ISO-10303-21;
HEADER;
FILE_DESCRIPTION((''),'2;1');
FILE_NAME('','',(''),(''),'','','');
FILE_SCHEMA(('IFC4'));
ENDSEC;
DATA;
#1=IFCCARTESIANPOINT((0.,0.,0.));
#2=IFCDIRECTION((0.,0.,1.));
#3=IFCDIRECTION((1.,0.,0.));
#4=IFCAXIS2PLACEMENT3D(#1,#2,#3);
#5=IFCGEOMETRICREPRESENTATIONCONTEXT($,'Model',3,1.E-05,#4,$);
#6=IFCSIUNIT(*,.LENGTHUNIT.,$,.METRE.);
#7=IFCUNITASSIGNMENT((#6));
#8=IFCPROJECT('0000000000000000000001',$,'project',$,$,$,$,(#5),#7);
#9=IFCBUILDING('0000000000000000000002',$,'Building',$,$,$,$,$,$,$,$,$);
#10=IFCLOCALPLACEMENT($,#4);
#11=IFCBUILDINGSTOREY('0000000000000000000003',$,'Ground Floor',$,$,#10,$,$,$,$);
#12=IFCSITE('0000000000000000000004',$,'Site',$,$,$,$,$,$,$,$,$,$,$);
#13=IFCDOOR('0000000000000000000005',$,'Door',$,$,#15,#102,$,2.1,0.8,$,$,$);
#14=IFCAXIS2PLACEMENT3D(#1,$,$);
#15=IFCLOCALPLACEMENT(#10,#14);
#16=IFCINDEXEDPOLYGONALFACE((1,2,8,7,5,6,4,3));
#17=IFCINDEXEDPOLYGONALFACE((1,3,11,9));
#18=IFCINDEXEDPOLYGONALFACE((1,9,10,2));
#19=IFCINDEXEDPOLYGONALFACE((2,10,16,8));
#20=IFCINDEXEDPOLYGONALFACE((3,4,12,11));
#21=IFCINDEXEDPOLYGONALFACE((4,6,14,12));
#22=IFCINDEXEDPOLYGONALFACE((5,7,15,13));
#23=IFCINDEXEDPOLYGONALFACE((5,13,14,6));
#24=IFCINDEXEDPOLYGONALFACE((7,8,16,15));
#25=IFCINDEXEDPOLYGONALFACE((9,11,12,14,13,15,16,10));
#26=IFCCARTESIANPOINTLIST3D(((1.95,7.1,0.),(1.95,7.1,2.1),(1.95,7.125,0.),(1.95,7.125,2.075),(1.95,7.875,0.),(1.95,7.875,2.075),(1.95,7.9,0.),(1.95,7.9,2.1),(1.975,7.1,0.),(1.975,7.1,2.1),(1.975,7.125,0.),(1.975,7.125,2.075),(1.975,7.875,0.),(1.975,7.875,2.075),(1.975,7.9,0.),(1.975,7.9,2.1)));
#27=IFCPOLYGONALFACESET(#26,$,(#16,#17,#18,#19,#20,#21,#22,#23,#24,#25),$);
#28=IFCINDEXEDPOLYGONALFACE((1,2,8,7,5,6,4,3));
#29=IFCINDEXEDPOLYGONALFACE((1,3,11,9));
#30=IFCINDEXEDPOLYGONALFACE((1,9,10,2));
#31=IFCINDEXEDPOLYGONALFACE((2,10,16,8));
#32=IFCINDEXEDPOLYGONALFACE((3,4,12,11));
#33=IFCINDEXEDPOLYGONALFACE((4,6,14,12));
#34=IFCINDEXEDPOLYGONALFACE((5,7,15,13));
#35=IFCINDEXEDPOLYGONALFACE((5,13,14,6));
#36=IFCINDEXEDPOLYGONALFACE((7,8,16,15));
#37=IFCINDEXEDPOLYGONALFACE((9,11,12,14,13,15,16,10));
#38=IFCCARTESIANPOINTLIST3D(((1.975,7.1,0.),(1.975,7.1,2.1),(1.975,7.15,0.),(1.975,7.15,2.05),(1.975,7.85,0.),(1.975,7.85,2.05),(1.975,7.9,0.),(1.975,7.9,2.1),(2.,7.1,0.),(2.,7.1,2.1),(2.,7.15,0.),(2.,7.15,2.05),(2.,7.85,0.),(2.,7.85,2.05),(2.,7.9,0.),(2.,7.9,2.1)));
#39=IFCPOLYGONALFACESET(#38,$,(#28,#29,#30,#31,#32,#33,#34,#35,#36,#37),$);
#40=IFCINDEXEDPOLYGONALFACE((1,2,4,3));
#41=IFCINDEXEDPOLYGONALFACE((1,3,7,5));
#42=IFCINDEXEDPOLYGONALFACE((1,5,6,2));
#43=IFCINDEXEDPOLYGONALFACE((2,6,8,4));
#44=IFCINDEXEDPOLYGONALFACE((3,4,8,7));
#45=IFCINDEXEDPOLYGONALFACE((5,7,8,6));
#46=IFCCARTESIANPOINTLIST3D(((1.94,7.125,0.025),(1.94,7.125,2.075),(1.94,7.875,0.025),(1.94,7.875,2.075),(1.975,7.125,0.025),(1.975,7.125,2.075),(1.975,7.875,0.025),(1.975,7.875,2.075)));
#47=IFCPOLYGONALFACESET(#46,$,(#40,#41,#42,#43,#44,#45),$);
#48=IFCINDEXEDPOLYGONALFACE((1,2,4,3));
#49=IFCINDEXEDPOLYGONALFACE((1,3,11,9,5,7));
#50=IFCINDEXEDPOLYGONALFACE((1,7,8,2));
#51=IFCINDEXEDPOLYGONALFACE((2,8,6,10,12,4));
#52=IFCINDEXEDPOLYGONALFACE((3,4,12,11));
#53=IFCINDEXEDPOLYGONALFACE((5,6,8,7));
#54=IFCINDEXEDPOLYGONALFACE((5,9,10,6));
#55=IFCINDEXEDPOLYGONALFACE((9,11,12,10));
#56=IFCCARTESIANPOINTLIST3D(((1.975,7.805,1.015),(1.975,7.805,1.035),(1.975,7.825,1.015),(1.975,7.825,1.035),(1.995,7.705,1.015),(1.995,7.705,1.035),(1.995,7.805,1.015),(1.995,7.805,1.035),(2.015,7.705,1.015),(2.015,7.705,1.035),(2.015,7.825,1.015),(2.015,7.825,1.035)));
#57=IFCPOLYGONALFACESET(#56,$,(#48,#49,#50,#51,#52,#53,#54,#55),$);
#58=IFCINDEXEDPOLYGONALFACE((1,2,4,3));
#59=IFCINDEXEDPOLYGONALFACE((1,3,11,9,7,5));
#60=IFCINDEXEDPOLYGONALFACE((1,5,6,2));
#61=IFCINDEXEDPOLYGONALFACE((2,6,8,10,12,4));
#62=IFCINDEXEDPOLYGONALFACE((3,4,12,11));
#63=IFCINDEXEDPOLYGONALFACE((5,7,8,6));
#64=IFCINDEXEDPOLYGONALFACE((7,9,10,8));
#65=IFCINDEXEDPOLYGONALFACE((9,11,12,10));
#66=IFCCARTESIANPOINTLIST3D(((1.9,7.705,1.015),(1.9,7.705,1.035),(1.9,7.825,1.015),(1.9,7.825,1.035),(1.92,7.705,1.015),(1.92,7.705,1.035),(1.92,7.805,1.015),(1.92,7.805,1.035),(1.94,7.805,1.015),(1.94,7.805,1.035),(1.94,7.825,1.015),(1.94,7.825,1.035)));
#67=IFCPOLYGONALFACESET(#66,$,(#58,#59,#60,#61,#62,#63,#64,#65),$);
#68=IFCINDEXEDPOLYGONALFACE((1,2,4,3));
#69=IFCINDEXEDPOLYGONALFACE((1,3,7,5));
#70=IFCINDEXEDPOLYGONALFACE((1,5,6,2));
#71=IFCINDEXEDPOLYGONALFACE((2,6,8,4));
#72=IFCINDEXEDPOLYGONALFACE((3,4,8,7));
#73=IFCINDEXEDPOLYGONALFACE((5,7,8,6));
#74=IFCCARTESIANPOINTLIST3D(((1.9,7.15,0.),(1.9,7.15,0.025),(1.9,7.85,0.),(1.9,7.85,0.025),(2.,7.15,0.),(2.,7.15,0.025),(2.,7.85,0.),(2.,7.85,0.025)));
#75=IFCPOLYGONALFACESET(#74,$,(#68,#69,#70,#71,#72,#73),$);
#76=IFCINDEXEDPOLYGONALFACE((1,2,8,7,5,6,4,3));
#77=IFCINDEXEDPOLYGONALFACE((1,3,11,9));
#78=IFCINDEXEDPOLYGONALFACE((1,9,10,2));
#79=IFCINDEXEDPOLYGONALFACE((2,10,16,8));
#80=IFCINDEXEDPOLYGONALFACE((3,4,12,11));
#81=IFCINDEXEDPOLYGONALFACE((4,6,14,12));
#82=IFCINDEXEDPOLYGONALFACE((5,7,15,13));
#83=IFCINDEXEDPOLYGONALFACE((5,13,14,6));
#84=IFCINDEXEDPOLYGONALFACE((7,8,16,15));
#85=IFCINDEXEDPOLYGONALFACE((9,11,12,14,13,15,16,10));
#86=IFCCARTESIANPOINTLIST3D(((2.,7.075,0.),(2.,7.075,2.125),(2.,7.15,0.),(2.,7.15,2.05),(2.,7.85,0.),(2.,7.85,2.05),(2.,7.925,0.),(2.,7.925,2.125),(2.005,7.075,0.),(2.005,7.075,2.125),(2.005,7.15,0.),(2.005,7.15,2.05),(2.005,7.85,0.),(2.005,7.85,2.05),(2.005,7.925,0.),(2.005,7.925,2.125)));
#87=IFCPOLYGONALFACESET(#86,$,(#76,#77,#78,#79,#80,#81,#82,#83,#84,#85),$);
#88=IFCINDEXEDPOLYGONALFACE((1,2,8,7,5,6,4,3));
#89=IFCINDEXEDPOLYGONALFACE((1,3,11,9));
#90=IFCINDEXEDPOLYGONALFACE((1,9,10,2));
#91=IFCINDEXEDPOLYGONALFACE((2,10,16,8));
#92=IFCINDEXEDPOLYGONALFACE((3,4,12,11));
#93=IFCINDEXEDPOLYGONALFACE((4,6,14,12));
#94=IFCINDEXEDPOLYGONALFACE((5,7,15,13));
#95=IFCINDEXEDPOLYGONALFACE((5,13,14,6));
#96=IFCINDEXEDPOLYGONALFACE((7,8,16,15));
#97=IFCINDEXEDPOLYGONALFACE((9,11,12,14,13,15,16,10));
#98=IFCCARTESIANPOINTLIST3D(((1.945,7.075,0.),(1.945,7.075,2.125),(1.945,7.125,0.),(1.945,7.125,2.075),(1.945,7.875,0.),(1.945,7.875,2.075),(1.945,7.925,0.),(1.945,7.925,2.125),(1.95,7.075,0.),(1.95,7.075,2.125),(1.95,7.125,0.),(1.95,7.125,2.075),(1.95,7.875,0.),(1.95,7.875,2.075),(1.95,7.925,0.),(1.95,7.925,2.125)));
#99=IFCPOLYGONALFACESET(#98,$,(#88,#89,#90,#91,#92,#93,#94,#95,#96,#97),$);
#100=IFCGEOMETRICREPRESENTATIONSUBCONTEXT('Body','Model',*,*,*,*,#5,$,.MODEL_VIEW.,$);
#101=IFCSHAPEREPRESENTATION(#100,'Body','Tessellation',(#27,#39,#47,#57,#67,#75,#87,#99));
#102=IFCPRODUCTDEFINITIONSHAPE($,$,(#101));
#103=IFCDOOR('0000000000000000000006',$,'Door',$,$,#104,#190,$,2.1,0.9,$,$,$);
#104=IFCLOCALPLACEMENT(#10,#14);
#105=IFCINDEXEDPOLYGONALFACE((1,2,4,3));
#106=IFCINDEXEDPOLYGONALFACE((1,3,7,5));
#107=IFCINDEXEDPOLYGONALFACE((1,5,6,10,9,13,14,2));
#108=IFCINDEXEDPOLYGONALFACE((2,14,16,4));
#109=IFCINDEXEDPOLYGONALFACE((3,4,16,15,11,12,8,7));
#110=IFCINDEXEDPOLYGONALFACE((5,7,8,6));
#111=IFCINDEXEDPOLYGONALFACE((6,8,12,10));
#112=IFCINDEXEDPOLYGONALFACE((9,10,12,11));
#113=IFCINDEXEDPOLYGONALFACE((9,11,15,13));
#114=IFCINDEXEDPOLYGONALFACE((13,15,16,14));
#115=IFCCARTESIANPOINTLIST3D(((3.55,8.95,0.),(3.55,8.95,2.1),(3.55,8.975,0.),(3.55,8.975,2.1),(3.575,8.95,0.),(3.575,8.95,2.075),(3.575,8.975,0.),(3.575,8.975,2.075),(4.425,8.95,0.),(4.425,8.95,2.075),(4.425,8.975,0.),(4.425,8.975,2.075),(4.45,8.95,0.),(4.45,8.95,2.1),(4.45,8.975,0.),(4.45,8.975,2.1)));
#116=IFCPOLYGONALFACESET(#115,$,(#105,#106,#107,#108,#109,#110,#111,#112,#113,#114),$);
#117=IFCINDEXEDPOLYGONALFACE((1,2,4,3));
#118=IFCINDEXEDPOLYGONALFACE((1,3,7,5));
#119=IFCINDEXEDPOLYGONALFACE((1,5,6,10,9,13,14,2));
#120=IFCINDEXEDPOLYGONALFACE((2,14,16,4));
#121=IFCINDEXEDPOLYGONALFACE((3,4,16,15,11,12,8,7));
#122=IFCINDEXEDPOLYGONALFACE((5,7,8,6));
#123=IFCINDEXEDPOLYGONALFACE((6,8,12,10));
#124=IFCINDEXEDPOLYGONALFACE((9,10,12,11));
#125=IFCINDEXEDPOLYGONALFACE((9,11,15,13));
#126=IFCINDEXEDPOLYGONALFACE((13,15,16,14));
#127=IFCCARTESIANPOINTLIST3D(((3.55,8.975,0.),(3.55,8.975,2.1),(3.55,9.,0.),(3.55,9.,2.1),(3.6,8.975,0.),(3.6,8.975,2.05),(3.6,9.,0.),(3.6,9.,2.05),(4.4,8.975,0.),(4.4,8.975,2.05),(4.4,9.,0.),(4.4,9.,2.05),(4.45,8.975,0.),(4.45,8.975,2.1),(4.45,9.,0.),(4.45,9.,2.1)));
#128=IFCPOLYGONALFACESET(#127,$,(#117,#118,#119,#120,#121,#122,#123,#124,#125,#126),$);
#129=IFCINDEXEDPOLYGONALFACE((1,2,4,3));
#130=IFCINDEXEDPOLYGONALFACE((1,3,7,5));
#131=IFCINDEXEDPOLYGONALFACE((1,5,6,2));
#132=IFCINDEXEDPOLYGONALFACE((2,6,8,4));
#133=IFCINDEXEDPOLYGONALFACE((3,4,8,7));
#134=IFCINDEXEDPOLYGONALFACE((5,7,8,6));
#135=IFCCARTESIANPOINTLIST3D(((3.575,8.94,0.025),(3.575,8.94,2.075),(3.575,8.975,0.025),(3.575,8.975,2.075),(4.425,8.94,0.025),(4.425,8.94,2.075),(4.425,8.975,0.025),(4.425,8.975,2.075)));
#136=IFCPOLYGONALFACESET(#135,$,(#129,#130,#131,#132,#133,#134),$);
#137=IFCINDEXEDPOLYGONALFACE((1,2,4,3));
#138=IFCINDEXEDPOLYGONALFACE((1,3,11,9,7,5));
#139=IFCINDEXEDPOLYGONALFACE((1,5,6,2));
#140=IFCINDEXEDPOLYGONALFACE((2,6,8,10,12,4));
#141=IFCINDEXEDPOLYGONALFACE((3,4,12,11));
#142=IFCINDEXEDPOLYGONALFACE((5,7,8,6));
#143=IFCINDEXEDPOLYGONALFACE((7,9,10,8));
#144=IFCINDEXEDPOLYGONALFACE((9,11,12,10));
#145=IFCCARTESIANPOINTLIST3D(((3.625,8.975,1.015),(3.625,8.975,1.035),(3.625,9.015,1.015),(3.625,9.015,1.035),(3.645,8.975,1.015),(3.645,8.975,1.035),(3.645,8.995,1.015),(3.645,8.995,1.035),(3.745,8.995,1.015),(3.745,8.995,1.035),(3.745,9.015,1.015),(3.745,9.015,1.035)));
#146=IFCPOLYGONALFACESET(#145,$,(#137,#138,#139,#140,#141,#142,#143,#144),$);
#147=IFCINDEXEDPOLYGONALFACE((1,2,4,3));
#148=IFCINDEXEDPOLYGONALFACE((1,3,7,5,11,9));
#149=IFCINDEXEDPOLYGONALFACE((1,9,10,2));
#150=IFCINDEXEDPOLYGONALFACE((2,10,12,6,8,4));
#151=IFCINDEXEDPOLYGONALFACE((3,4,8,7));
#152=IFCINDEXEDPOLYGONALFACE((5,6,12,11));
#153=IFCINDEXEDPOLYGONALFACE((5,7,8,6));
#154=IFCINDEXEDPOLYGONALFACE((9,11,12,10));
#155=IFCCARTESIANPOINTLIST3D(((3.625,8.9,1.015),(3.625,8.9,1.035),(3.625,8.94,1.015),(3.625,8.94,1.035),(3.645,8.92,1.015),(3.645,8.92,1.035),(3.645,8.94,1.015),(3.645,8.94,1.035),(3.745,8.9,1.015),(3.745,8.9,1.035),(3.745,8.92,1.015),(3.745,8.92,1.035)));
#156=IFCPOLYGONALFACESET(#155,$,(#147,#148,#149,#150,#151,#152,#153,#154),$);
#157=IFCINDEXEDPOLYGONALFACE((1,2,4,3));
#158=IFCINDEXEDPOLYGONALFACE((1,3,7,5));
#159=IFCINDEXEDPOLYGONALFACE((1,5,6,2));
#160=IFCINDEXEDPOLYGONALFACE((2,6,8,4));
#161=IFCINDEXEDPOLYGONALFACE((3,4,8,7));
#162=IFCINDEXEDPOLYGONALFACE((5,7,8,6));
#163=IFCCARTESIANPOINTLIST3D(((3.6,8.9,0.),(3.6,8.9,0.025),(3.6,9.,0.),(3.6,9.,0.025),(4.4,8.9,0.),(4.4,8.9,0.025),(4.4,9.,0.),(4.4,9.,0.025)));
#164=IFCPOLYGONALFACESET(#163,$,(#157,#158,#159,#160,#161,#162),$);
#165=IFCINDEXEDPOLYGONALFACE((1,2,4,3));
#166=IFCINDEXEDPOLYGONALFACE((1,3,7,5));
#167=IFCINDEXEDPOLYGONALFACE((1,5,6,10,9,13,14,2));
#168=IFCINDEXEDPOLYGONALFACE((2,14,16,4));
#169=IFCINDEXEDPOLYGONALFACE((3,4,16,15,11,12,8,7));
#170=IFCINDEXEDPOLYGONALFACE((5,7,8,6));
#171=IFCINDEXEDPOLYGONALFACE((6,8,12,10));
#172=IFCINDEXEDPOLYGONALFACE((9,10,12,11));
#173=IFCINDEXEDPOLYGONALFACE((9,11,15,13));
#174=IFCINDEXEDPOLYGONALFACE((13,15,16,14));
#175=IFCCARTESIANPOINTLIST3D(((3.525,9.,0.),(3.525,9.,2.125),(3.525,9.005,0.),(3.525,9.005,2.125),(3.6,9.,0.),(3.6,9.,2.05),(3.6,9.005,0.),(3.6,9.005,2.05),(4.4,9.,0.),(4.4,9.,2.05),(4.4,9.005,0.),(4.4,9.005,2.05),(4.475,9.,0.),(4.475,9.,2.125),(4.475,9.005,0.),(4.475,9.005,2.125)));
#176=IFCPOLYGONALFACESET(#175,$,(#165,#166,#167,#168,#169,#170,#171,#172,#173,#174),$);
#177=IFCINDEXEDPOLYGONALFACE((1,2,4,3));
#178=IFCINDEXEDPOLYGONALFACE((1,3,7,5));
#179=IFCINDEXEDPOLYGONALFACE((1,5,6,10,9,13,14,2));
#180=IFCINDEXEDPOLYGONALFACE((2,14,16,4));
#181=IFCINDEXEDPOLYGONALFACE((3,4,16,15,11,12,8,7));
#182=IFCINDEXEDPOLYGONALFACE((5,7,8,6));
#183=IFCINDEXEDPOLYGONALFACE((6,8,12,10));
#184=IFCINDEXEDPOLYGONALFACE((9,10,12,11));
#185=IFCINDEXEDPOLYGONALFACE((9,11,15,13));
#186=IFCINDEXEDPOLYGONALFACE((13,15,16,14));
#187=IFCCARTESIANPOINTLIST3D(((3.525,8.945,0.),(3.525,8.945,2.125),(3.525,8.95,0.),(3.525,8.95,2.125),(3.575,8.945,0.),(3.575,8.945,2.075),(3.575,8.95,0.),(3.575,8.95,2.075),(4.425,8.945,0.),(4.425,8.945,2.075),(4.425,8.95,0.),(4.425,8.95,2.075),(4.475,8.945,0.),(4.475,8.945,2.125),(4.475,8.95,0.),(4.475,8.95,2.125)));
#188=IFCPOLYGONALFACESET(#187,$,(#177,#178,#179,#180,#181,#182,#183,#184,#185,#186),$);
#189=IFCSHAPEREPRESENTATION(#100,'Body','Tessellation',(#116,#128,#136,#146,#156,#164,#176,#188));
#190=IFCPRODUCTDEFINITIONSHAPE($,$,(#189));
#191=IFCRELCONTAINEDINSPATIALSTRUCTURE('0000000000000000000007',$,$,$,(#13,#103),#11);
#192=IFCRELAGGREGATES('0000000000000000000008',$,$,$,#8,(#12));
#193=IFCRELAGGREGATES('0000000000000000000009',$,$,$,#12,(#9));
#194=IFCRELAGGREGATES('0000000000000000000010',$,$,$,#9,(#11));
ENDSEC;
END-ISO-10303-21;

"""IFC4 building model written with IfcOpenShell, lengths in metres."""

from ifc_helpers import new_model, si_unit, frame, origin_with_axes, place, context, subcontext, project, spatial, line, indexed_curve, outline, extrude, element, save


model = new_model("IFC4")

# Units and contexts
model_context = context("Model", 3, precision=1e-05, world=origin_with_axes())
body_context = subcontext(model_context, "Body", "Model", "MODEL_VIEW")
ifc_project = project(units=[si_unit("LENGTHUNIT", "METRE")], contexts=[model_context])

# Site, building, storey
site = spatial("IfcSite", under=ifc_project, Name="Site")
building = spatial("IfcBuilding", under=site, Name="Building")
storey_placement = place(None, origin_with_axes())
storey = spatial("IfcBuildingStorey", under=building, at=storey_placement, Name="Ground Floor")

# Doors
door_1_placement = place(storey_placement, frame((2.0, 7.1, 0.0), z_axis=(0.0, 0.0, 1.0), x_axis=(0.0, 1.0, 0.0)))
element("IfcDoor", 1, at=door_1_placement, inside=storey, Name="Door", OverallHeight=2.1, OverallWidth=0.8, context=body_context, shape_type="SweptSolid", body=[
    extrude(outline(indexed_curve([(0.0, 0.0), (0.0, 2.1), (0.8, 2.1), (0.8, 0.0), (0.775, 0.0), (0.775, 2.075), (0.025, 2.075), (0.025, 0.0)], segments=[line(1, 2, 3, 4, 5, 6, 7, 8, 1)])), frame((0.0, 0.025, 0.0), z_axis=(0.0, -1.0, 0.0), x_axis=(1.0, 0.0, 0.0)), (0.0, 0.0, -1.0), 0.025),
    extrude(outline(indexed_curve([(0.0, 0.0), (0.0, 2.1), (0.8, 2.1), (0.8, 0.0), (0.75, 0.0), (0.75, 2.05), (0.05, 2.05), (0.05, 0.0)], segments=[line(1, 2, 3, 4, 5, 6, 7, 8, 1)])), frame((0.0, 0.0, 0.0), z_axis=(0.0, -1.0, 0.0), x_axis=(1.0, 0.0, 0.0)), (0.0, 0.0, -1.0), 0.025),
    extrude(outline(indexed_curve([(0.0, 0.0), (0.75, 0.0), (0.75, 0.035), (0.0, 0.035)], segments=[line(1, 2, 3, 4, 1)])), frame((0.025, 0.025, 0.025), z_axis=(0.0, 0.0, 1.0), x_axis=(1.0, 0.0, 0.0)), (0.0, 0.0, 1.0), 2.05),
    extrude(outline(indexed_curve([(0.0, 0.0), (0.0, -0.04), (-0.12, -0.04), (-0.12, -0.02), (-0.02, -0.02), (-0.02, 0.0)], segments=[line(1, 2, 3, 4, 5, 6, 1)])), frame((0.725, 0.025, 1.015), z_axis=(0.0, 0.0, 1.0), x_axis=(1.0, 0.0, 0.0)), (0.0, 0.0, 1.0), 0.02),
    extrude(outline(indexed_curve([(0.0, 0.0), (0.0, 0.04), (-0.12, 0.04), (-0.12, 0.02), (-0.02, 0.02), (-0.02, 0.0)], segments=[line(1, 2, 3, 4, 5, 6, 1)])), frame((0.725, 0.06, 1.015), z_axis=(0.0, 0.0, 1.0), x_axis=(1.0, 0.0, 0.0)), (0.0, 0.0, 1.0), 0.02),
    extrude(outline(indexed_curve([(0.0, 0.0), (0.7, 0.0), (0.7, 0.1), (0.0, 0.1)], segments=[line(1, 2, 3, 4, 1)])), frame((0.05, 0.0, 0.0), z_axis=(0.0, 0.0, 1.0), x_axis=(1.0, 0.0, 0.0)), (0.0, 0.0, 1.0), 0.025),
    extrude(outline(indexed_curve([(0.0, 0.0), (0.0, 2.125), (0.85, 2.125), (0.85, 0.0), (0.775, 0.0), (0.775, 2.05), (0.075, 2.05), (0.075, 0.0)], segments=[line(1, 2, 3, 4, 5, 6, 7, 8, 1)])), frame((-0.025, -0.005, 0.0), z_axis=(0.0, -1.0, 0.0), x_axis=(1.0, 0.0, 0.0)), (0.0, 0.0, -1.0), 0.005),
    extrude(outline(indexed_curve([(0.0, 0.0), (0.0, 2.125), (0.85, 2.125), (0.85, 0.0), (0.8, 0.0), (0.8, 2.075), (0.05, 2.075), (0.05, 0.0)], segments=[line(1, 2, 3, 4, 5, 6, 7, 8, 1)])), frame((-0.025, 0.05, 0.0), z_axis=(0.0, -1.0, 0.0), x_axis=(1.0, 0.0, 0.0)), (0.0, 0.0, -1.0), 0.005),
])
door_2_placement = place(storey_placement, frame((4.45, 9.0, 0.0), z_axis=(0.0, 0.0, 1.0), x_axis=(-1.0, 0.0, 0.0)))
element("IfcDoor", 2, at=door_2_placement, inside=storey, Name="Door", OverallHeight=2.1, OverallWidth=0.9, context=body_context, shape_type="SweptSolid", body=[
    extrude(outline(indexed_curve([(0.0, 0.0), (0.0, 2.1), (0.9, 2.1), (0.9, 0.0), (0.875, 0.0), (0.875, 2.075), (0.025, 2.075), (0.025, 0.0)], segments=[line(1, 2, 3, 4, 5, 6, 7, 8, 1)])), frame((0.0, 0.025, 0.0), z_axis=(0.0, -1.0, 0.0), x_axis=(1.0, 0.0, 0.0)), (0.0, 0.0, -1.0), 0.025),
    extrude(outline(indexed_curve([(0.0, 0.0), (0.0, 2.1), (0.9, 2.1), (0.9, 0.0), (0.85, 0.0), (0.85, 2.05), (0.05, 2.05), (0.05, 0.0)], segments=[line(1, 2, 3, 4, 5, 6, 7, 8, 1)])), frame((0.0, 0.0, 0.0), z_axis=(0.0, -1.0, 0.0), x_axis=(1.0, 0.0, 0.0)), (0.0, 0.0, -1.0), 0.025),
    extrude(outline(indexed_curve([(0.0, 0.0), (0.85, 0.0), (0.85, 0.035), (0.0, 0.035)], segments=[line(1, 2, 3, 4, 1)])), frame((0.025, 0.025, 0.025), z_axis=(0.0, 0.0, 1.0), x_axis=(1.0, 0.0, 0.0)), (0.0, 0.0, 1.0), 2.05),
    extrude(outline(indexed_curve([(0.0, 0.0), (0.0, -0.04), (-0.12, -0.04), (-0.12, -0.02), (-0.02, -0.02), (-0.02, 0.0)], segments=[line(1, 2, 3, 4, 5, 6, 1)])), frame((0.825, 0.025, 1.015), z_axis=(0.0, 0.0, 1.0), x_axis=(1.0, 0.0, 0.0)), (0.0, 0.0, 1.0), 0.02),
    extrude(outline(indexed_curve([(0.0, 0.0), (0.0, 0.04), (-0.12, 0.04), (-0.12, 0.02), (-0.02, 0.02), (-0.02, 0.0)], segments=[line(1, 2, 3, 4, 5, 6, 1)])), frame((0.825, 0.06, 1.015), z_axis=(0.0, 0.0, 1.0), x_axis=(1.0, 0.0, 0.0)), (0.0, 0.0, 1.0), 0.02),
    extrude(outline(indexed_curve([(0.0, 0.0), (0.8, 0.0), (0.8, 0.1), (0.0, 0.1)], segments=[line(1, 2, 3, 4, 1)])), frame((0.05, 0.0, 0.0), z_axis=(0.0, 0.0, 1.0), x_axis=(1.0, 0.0, 0.0)), (0.0, 0.0, 1.0), 0.025),
    extrude(outline(indexed_curve([(0.0, 0.0), (0.0, 2.125), (0.95, 2.125), (0.95, 0.0), (0.875, 0.0), (0.875, 2.05), (0.075, 2.05), (0.075, 0.0)], segments=[line(1, 2, 3, 4, 5, 6, 7, 8, 1)])), frame((-0.025, -0.005, 0.0), z_axis=(0.0, -1.0, 0.0), x_axis=(1.0, 0.0, 0.0)), (0.0, 0.0, -1.0), 0.005),
    extrude(outline(indexed_curve([(0.0, 0.0), (0.0, 2.125), (0.95, 2.125), (0.95, 0.0), (0.9, 0.0), (0.9, 2.075), (0.05, 2.075), (0.05, 0.0)], segments=[line(1, 2, 3, 4, 5, 6, 7, 8, 1)])), frame((-0.025, 0.05, 0.0), z_axis=(0.0, -1.0, 0.0), x_axis=(1.0, 0.0, 0.0)), (0.0, 0.0, -1.0), 0.005),
])

save(model, "model.ifc")
